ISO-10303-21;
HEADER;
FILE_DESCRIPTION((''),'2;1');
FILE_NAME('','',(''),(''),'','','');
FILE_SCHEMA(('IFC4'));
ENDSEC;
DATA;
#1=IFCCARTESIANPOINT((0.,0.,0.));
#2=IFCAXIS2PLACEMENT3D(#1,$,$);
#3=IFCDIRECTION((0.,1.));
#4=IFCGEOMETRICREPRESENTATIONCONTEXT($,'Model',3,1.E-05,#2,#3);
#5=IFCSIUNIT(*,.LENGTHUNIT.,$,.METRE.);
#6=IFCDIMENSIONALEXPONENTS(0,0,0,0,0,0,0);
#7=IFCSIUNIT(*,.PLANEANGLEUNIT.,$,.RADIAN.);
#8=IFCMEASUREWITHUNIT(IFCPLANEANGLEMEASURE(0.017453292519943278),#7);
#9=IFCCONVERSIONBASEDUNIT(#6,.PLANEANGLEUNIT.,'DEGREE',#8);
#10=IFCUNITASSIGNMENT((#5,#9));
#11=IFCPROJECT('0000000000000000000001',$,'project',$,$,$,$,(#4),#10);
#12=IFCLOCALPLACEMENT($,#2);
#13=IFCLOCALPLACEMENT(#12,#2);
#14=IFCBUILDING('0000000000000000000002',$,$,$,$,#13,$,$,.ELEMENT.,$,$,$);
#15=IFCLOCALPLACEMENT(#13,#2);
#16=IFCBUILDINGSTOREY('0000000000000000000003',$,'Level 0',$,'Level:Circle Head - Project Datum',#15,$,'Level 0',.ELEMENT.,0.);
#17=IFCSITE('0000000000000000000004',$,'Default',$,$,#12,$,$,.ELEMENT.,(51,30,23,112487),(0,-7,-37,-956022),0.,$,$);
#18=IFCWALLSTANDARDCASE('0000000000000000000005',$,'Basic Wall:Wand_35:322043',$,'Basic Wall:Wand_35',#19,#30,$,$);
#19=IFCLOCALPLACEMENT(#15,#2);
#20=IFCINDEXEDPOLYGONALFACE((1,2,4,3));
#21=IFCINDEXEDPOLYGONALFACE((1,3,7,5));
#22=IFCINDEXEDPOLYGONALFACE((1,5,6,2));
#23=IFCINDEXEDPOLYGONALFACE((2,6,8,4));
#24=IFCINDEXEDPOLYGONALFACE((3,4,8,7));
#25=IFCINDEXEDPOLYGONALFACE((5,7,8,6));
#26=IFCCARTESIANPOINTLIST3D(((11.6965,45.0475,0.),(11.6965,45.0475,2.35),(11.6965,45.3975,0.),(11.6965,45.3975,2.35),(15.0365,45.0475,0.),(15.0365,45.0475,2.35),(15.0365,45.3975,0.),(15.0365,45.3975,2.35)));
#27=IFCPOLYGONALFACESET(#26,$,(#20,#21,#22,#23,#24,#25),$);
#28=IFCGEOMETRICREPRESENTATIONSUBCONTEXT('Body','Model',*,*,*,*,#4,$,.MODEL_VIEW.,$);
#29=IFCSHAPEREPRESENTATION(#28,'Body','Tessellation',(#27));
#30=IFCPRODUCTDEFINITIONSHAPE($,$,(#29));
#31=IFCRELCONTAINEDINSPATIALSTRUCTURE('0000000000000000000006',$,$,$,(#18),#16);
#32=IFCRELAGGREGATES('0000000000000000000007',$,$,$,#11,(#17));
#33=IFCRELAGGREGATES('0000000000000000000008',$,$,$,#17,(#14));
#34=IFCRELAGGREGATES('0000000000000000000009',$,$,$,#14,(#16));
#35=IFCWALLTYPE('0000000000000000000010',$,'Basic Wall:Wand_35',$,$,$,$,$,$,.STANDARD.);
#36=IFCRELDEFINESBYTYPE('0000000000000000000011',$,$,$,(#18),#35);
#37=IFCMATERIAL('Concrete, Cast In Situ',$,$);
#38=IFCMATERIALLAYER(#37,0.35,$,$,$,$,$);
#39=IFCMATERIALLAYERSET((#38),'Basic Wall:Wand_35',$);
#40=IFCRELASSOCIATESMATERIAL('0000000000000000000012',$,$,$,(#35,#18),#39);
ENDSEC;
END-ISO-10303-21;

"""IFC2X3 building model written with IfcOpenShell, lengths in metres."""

from ifc_helpers import new_model, entity, si_unit, converted_unit, direction, frame, frame_2d, origin, place, context, subcontext, project, spatial, rectangle, extrude, material, layer, layer_set, layer_usage, type_object, element, save


model = new_model("IFC2X3")

# Units and contexts
model_context = context("Model", 3, precision=1e-05, world=origin(), true_north=direction((0.0, 1.0)))
body_context = subcontext(model_context, "Body", "Model", "MODEL_VIEW")
ifc_project = project(units=[si_unit("LENGTHUNIT", "METRE"), converted_unit("PLANEANGLEUNIT", "DEGREE", entity("IfcPlaneAngleMeasure", 0.017453292519943278), si_unit("PLANEANGLEUNIT", "RADIAN"), dimensions=[0, 0, 0, 0, 0, 0, 0])], contexts=[model_context])

# Site, building, storey
site_placement = place(None, origin())
site = spatial("IfcSite", under=ifc_project, at=site_placement, Name="Default", CompositionType="ELEMENT", RefLatitude=(51, 30, 23, 112487), RefLongitude=(0, -7, -37, -956022), RefElevation=0.0)
building_placement = place(site_placement, origin())
building = spatial("IfcBuilding", under=site, at=building_placement, CompositionType="ELEMENT")
storey_placement = place(building_placement, origin())
storey = spatial("IfcBuildingStorey", under=building, at=storey_placement, Name="Level 0", ObjectType="Level:Circle Head - Project Datum", LongName="Level 0", CompositionType="ELEMENT", Elevation=0.0)

# Shared definitions
ifc_material_1 = material(Name="Concrete, Cast In Situ")

# Wall
ifc_layer_1 = layer(ifc_material_1, 0.35)
ifc_layer_set_1 = layer_set([ifc_layer_1], Name="Basic Wall:Wand_35")
ifc_layer_usage_1 = layer_usage(ifc_layer_set_1, "AXIS2", "NEGATIVE", 0.175)
wall_type_1 = type_object("IfcWallType", Name="Basic Wall:Wand_35", PredefinedType="STANDARD", material=ifc_layer_set_1)
wall_1_placement = place(storey_placement, frame((15.0365, 45.2225, 0.0), z_axis=(0.0, 0.0, 1.0), x_axis=(-1.0, 0.0, 0.0)))
element("IfcWallStandardCase", 1, at=wall_1_placement, inside=storey, type_object=wall_type_1, material=ifc_layer_usage_1, Name="Basic Wall:Wand_35:322043", ObjectType="Basic Wall:Wand_35", context=body_context, shape_type="SweptSolid", body=[
    extrude(rectangle(XDim=3.34, YDim=0.35, at=frame_2d((1.67, 0.0), x_axis=(-1.0, 0.0))), origin(), (0.0, 0.0, 1.0), 2.35),
])

save(model, "model.ifc")
